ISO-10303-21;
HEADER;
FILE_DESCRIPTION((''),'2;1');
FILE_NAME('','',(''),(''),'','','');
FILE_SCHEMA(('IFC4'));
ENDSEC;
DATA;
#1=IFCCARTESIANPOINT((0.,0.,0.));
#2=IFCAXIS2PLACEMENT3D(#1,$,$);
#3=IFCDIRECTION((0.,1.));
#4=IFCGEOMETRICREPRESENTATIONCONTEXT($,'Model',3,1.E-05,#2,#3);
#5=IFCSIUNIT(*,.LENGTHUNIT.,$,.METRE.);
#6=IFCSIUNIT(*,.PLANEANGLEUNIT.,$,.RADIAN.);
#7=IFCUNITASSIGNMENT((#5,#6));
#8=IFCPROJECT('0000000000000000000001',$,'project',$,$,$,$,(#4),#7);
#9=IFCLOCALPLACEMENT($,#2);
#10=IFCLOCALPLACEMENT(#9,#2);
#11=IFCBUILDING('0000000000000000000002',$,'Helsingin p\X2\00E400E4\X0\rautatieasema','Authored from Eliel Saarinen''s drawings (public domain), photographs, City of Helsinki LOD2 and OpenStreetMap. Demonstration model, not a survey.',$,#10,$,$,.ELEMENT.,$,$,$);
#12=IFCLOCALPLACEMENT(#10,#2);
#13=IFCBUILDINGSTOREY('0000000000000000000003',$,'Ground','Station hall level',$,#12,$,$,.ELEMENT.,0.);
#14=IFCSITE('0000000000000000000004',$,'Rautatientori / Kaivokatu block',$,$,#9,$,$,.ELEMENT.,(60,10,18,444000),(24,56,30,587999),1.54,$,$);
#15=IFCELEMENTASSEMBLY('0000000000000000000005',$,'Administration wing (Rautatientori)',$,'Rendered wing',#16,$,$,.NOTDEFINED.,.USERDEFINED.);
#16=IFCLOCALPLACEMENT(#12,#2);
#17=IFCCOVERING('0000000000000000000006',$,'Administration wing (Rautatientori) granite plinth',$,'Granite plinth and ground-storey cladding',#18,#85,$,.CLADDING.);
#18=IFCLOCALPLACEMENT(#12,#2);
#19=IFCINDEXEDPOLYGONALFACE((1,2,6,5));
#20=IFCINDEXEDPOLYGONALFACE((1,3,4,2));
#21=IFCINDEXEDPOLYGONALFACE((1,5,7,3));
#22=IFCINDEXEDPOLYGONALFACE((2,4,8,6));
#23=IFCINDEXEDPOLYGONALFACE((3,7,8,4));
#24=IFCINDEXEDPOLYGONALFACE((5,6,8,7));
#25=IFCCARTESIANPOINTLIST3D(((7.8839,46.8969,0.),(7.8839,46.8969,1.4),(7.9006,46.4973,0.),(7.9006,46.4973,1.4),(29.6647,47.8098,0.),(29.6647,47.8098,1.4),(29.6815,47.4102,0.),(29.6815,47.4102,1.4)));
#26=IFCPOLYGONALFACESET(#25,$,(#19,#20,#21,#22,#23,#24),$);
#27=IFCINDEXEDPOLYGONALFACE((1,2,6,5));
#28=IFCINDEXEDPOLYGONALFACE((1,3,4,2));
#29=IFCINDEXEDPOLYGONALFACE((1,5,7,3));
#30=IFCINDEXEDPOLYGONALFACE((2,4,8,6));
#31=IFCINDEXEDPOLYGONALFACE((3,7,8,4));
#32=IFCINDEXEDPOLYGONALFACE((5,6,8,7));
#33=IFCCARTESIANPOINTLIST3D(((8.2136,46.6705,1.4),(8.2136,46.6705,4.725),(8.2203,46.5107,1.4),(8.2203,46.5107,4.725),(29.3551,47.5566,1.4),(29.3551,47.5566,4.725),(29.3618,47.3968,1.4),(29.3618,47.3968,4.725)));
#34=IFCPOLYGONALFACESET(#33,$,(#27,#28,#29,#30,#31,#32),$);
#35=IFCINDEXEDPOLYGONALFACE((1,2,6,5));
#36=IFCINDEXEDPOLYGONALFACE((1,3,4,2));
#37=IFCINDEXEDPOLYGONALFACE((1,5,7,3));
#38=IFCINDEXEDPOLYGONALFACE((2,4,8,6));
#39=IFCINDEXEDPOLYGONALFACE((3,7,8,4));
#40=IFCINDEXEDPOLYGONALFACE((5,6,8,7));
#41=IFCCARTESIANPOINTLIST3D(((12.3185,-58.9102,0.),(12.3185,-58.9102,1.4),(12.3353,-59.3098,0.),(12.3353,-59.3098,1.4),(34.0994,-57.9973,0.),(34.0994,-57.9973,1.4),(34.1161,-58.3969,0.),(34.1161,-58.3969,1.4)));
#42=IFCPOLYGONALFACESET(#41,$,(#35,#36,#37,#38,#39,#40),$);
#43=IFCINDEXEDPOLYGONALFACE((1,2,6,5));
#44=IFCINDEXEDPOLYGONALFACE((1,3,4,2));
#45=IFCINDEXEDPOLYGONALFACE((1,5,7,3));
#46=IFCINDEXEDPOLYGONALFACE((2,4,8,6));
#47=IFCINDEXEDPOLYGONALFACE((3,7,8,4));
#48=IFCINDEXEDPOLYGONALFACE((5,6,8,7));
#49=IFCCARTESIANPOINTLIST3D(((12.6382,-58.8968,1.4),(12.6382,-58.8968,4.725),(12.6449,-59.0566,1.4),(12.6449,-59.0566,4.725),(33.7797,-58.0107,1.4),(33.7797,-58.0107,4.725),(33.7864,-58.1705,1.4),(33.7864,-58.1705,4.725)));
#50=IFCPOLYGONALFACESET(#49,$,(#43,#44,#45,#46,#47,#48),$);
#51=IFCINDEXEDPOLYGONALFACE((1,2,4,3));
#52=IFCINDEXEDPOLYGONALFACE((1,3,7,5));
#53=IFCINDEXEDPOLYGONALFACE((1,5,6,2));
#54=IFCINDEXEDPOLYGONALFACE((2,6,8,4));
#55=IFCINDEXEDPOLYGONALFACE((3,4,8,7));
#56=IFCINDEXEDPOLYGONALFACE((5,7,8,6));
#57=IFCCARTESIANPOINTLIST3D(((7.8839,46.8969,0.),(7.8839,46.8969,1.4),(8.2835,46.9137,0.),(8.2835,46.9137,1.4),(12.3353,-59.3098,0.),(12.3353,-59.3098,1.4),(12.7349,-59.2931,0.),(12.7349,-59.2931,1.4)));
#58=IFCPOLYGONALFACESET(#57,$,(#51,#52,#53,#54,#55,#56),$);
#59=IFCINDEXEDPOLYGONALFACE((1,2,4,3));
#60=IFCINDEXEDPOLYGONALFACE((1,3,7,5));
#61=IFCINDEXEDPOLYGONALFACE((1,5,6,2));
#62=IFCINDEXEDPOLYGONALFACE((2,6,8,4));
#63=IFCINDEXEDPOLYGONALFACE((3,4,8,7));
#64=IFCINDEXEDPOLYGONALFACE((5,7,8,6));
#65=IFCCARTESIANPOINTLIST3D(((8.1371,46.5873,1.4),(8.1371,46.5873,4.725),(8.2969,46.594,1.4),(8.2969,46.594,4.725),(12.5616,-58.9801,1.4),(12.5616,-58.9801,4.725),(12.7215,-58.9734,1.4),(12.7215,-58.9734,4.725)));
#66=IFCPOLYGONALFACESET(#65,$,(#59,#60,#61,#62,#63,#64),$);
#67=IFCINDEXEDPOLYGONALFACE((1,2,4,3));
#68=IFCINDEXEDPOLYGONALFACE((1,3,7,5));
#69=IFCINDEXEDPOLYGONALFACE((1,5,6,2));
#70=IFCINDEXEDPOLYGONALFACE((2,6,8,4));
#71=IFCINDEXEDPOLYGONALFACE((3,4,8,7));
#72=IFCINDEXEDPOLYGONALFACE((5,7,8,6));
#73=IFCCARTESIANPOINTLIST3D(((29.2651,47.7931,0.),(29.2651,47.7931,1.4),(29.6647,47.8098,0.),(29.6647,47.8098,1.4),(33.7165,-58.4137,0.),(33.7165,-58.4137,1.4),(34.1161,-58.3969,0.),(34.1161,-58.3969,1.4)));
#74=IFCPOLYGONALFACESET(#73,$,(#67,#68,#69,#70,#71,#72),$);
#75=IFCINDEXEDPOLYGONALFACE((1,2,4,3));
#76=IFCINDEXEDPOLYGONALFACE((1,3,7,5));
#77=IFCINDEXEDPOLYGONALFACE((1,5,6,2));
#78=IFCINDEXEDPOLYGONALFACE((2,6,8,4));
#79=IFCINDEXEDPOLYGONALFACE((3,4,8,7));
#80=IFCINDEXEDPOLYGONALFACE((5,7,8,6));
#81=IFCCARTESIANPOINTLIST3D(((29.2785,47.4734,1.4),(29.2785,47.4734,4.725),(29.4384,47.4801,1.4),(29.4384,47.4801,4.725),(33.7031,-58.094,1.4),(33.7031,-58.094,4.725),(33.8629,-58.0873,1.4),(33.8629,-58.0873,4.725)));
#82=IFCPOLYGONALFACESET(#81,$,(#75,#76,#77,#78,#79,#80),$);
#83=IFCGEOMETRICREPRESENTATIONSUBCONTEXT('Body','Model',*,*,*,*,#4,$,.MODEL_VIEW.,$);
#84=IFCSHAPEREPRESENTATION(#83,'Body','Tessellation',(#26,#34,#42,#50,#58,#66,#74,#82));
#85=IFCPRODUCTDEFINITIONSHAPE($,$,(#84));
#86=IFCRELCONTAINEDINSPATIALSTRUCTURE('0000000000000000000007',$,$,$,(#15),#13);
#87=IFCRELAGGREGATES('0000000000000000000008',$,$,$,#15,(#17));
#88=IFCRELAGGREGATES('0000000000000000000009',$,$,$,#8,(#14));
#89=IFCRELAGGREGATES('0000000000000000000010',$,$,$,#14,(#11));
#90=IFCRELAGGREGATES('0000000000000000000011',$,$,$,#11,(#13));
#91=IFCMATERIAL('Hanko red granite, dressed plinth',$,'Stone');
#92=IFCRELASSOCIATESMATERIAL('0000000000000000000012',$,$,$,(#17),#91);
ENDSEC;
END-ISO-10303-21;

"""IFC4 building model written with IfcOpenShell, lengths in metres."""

from ifc_helpers import new_model, si_unit, direction, frame, frame_2d, origin, place, context, subcontext, project, spatial, rectangle, extrude, material, element, aggregate, save


model = new_model("IFC4")

# Units and contexts
model_context = context("Model", 3, precision=1e-05, world=origin(), true_north=direction((0.0, 1.0)))
body_context = subcontext(model_context, "Body", "Model", "MODEL_VIEW")
ifc_project = project(units=[si_unit("LENGTHUNIT", "METRE"), si_unit("PLANEANGLEUNIT", "RADIAN")], contexts=[model_context])

# Site, building, storey
site_placement = place(None, origin())
site = spatial("IfcSite", under=ifc_project, at=site_placement, Name="Rautatientori / Kaivokatu block", CompositionType="ELEMENT", RefLatitude=(60, 10, 18, 444000), RefLongitude=(24, 56, 30, 587999), RefElevation=1.54)
building_placement = place(site_placement, origin())
building = spatial("IfcBuilding", under=site, at=building_placement, Name="Helsingin päärautatieasema", Description="Authored from Eliel Saarinen's drawings (public domain), photographs, City of Helsinki LOD2 and OpenStreetMap. Demonstration model, not a survey.", CompositionType="ELEMENT")
storey_placement = place(building_placement, origin())
storey = spatial("IfcBuildingStorey", under=building, at=storey_placement, Name="Ground", Description="Station hall level", CompositionType="ELEMENT", Elevation=0.0)

# Element assembly, covering
assembly_placement = place(building_placement, origin())
assembly = element("IfcElementAssembly", 1, at=assembly_placement, inside=storey, Name="Administration wing (Rautatientori)", ObjectType="Rendered wing", AssemblyPlace="NOTDEFINED", PredefinedType="USERDEFINED")
ifc_material_1 = material(Name="Hanko red granite, dressed plinth", Category="Stone")
covering_placement = place(building_placement, origin())
covering = element("IfcCovering", 2, at=covering_placement, material=ifc_material_1, Name="Administration wing (Rautatientori) granite plinth", ObjectType="Granite plinth and ground-storey cladding", PredefinedType="CLADDING", context=body_context, shape_type="SweptSolid", body=[
    extrude(rectangle(XDim=21.8, YDim=0.4, at=frame_2d((0.0, 0.0), x_axis=(-0.999123, -0.041876))), frame((18.7827, 47.1536, 0.0)), (0.0, 0.0, 1.0), 1.4),
    extrude(rectangle(XDim=21.16, YDim=0.16, at=frame_2d((0.0, 0.0), x_axis=(-0.999123, -0.041876))), frame((18.7877, 47.0337, 1.4)), (0.0, 0.0, 1.0), 3.325),
    extrude(rectangle(XDim=21.8, YDim=0.4, at=frame_2d((0.0, 0.0), x_axis=(0.999123, 0.041876))), frame((23.2173, -58.6536, 0.0)), (0.0, 0.0, 1.0), 1.4),
    extrude(rectangle(XDim=21.16, YDim=0.16, at=frame_2d((0.0, 0.0), x_axis=(0.999123, 0.041876))), frame((23.2123, -58.5337, 1.4)), (0.0, 0.0, 1.0), 3.325),
    extrude(rectangle(XDim=106.3, YDim=0.4, at=frame_2d((0.0, 0.0), x_axis=(0.041876, -0.999123))), frame((10.3094, -6.1981, 0.0)), (0.0, 0.0, 1.0), 1.4),
    extrude(rectangle(XDim=105.66, YDim=0.16, at=frame_2d((0.0, 0.0), x_axis=(0.041876, -0.999123))), frame((10.4293, -6.193, 1.4)), (0.0, 0.0, 1.0), 3.325),
    extrude(rectangle(XDim=106.3, YDim=0.4, at=frame_2d((0.0, 0.0), x_axis=(-0.041876, 0.999123))), frame((31.6906, -5.3019, 0.0)), (0.0, 0.0, 1.0), 1.4),
    extrude(rectangle(XDim=105.66, YDim=0.16, at=frame_2d((0.0, 0.0), x_axis=(-0.041876, 0.999123))), frame((31.5707, -5.307, 1.4)), (0.0, 0.0, 1.0), 3.325),
])
aggregate(assembly, [covering])

save(model, "model.ifc")
